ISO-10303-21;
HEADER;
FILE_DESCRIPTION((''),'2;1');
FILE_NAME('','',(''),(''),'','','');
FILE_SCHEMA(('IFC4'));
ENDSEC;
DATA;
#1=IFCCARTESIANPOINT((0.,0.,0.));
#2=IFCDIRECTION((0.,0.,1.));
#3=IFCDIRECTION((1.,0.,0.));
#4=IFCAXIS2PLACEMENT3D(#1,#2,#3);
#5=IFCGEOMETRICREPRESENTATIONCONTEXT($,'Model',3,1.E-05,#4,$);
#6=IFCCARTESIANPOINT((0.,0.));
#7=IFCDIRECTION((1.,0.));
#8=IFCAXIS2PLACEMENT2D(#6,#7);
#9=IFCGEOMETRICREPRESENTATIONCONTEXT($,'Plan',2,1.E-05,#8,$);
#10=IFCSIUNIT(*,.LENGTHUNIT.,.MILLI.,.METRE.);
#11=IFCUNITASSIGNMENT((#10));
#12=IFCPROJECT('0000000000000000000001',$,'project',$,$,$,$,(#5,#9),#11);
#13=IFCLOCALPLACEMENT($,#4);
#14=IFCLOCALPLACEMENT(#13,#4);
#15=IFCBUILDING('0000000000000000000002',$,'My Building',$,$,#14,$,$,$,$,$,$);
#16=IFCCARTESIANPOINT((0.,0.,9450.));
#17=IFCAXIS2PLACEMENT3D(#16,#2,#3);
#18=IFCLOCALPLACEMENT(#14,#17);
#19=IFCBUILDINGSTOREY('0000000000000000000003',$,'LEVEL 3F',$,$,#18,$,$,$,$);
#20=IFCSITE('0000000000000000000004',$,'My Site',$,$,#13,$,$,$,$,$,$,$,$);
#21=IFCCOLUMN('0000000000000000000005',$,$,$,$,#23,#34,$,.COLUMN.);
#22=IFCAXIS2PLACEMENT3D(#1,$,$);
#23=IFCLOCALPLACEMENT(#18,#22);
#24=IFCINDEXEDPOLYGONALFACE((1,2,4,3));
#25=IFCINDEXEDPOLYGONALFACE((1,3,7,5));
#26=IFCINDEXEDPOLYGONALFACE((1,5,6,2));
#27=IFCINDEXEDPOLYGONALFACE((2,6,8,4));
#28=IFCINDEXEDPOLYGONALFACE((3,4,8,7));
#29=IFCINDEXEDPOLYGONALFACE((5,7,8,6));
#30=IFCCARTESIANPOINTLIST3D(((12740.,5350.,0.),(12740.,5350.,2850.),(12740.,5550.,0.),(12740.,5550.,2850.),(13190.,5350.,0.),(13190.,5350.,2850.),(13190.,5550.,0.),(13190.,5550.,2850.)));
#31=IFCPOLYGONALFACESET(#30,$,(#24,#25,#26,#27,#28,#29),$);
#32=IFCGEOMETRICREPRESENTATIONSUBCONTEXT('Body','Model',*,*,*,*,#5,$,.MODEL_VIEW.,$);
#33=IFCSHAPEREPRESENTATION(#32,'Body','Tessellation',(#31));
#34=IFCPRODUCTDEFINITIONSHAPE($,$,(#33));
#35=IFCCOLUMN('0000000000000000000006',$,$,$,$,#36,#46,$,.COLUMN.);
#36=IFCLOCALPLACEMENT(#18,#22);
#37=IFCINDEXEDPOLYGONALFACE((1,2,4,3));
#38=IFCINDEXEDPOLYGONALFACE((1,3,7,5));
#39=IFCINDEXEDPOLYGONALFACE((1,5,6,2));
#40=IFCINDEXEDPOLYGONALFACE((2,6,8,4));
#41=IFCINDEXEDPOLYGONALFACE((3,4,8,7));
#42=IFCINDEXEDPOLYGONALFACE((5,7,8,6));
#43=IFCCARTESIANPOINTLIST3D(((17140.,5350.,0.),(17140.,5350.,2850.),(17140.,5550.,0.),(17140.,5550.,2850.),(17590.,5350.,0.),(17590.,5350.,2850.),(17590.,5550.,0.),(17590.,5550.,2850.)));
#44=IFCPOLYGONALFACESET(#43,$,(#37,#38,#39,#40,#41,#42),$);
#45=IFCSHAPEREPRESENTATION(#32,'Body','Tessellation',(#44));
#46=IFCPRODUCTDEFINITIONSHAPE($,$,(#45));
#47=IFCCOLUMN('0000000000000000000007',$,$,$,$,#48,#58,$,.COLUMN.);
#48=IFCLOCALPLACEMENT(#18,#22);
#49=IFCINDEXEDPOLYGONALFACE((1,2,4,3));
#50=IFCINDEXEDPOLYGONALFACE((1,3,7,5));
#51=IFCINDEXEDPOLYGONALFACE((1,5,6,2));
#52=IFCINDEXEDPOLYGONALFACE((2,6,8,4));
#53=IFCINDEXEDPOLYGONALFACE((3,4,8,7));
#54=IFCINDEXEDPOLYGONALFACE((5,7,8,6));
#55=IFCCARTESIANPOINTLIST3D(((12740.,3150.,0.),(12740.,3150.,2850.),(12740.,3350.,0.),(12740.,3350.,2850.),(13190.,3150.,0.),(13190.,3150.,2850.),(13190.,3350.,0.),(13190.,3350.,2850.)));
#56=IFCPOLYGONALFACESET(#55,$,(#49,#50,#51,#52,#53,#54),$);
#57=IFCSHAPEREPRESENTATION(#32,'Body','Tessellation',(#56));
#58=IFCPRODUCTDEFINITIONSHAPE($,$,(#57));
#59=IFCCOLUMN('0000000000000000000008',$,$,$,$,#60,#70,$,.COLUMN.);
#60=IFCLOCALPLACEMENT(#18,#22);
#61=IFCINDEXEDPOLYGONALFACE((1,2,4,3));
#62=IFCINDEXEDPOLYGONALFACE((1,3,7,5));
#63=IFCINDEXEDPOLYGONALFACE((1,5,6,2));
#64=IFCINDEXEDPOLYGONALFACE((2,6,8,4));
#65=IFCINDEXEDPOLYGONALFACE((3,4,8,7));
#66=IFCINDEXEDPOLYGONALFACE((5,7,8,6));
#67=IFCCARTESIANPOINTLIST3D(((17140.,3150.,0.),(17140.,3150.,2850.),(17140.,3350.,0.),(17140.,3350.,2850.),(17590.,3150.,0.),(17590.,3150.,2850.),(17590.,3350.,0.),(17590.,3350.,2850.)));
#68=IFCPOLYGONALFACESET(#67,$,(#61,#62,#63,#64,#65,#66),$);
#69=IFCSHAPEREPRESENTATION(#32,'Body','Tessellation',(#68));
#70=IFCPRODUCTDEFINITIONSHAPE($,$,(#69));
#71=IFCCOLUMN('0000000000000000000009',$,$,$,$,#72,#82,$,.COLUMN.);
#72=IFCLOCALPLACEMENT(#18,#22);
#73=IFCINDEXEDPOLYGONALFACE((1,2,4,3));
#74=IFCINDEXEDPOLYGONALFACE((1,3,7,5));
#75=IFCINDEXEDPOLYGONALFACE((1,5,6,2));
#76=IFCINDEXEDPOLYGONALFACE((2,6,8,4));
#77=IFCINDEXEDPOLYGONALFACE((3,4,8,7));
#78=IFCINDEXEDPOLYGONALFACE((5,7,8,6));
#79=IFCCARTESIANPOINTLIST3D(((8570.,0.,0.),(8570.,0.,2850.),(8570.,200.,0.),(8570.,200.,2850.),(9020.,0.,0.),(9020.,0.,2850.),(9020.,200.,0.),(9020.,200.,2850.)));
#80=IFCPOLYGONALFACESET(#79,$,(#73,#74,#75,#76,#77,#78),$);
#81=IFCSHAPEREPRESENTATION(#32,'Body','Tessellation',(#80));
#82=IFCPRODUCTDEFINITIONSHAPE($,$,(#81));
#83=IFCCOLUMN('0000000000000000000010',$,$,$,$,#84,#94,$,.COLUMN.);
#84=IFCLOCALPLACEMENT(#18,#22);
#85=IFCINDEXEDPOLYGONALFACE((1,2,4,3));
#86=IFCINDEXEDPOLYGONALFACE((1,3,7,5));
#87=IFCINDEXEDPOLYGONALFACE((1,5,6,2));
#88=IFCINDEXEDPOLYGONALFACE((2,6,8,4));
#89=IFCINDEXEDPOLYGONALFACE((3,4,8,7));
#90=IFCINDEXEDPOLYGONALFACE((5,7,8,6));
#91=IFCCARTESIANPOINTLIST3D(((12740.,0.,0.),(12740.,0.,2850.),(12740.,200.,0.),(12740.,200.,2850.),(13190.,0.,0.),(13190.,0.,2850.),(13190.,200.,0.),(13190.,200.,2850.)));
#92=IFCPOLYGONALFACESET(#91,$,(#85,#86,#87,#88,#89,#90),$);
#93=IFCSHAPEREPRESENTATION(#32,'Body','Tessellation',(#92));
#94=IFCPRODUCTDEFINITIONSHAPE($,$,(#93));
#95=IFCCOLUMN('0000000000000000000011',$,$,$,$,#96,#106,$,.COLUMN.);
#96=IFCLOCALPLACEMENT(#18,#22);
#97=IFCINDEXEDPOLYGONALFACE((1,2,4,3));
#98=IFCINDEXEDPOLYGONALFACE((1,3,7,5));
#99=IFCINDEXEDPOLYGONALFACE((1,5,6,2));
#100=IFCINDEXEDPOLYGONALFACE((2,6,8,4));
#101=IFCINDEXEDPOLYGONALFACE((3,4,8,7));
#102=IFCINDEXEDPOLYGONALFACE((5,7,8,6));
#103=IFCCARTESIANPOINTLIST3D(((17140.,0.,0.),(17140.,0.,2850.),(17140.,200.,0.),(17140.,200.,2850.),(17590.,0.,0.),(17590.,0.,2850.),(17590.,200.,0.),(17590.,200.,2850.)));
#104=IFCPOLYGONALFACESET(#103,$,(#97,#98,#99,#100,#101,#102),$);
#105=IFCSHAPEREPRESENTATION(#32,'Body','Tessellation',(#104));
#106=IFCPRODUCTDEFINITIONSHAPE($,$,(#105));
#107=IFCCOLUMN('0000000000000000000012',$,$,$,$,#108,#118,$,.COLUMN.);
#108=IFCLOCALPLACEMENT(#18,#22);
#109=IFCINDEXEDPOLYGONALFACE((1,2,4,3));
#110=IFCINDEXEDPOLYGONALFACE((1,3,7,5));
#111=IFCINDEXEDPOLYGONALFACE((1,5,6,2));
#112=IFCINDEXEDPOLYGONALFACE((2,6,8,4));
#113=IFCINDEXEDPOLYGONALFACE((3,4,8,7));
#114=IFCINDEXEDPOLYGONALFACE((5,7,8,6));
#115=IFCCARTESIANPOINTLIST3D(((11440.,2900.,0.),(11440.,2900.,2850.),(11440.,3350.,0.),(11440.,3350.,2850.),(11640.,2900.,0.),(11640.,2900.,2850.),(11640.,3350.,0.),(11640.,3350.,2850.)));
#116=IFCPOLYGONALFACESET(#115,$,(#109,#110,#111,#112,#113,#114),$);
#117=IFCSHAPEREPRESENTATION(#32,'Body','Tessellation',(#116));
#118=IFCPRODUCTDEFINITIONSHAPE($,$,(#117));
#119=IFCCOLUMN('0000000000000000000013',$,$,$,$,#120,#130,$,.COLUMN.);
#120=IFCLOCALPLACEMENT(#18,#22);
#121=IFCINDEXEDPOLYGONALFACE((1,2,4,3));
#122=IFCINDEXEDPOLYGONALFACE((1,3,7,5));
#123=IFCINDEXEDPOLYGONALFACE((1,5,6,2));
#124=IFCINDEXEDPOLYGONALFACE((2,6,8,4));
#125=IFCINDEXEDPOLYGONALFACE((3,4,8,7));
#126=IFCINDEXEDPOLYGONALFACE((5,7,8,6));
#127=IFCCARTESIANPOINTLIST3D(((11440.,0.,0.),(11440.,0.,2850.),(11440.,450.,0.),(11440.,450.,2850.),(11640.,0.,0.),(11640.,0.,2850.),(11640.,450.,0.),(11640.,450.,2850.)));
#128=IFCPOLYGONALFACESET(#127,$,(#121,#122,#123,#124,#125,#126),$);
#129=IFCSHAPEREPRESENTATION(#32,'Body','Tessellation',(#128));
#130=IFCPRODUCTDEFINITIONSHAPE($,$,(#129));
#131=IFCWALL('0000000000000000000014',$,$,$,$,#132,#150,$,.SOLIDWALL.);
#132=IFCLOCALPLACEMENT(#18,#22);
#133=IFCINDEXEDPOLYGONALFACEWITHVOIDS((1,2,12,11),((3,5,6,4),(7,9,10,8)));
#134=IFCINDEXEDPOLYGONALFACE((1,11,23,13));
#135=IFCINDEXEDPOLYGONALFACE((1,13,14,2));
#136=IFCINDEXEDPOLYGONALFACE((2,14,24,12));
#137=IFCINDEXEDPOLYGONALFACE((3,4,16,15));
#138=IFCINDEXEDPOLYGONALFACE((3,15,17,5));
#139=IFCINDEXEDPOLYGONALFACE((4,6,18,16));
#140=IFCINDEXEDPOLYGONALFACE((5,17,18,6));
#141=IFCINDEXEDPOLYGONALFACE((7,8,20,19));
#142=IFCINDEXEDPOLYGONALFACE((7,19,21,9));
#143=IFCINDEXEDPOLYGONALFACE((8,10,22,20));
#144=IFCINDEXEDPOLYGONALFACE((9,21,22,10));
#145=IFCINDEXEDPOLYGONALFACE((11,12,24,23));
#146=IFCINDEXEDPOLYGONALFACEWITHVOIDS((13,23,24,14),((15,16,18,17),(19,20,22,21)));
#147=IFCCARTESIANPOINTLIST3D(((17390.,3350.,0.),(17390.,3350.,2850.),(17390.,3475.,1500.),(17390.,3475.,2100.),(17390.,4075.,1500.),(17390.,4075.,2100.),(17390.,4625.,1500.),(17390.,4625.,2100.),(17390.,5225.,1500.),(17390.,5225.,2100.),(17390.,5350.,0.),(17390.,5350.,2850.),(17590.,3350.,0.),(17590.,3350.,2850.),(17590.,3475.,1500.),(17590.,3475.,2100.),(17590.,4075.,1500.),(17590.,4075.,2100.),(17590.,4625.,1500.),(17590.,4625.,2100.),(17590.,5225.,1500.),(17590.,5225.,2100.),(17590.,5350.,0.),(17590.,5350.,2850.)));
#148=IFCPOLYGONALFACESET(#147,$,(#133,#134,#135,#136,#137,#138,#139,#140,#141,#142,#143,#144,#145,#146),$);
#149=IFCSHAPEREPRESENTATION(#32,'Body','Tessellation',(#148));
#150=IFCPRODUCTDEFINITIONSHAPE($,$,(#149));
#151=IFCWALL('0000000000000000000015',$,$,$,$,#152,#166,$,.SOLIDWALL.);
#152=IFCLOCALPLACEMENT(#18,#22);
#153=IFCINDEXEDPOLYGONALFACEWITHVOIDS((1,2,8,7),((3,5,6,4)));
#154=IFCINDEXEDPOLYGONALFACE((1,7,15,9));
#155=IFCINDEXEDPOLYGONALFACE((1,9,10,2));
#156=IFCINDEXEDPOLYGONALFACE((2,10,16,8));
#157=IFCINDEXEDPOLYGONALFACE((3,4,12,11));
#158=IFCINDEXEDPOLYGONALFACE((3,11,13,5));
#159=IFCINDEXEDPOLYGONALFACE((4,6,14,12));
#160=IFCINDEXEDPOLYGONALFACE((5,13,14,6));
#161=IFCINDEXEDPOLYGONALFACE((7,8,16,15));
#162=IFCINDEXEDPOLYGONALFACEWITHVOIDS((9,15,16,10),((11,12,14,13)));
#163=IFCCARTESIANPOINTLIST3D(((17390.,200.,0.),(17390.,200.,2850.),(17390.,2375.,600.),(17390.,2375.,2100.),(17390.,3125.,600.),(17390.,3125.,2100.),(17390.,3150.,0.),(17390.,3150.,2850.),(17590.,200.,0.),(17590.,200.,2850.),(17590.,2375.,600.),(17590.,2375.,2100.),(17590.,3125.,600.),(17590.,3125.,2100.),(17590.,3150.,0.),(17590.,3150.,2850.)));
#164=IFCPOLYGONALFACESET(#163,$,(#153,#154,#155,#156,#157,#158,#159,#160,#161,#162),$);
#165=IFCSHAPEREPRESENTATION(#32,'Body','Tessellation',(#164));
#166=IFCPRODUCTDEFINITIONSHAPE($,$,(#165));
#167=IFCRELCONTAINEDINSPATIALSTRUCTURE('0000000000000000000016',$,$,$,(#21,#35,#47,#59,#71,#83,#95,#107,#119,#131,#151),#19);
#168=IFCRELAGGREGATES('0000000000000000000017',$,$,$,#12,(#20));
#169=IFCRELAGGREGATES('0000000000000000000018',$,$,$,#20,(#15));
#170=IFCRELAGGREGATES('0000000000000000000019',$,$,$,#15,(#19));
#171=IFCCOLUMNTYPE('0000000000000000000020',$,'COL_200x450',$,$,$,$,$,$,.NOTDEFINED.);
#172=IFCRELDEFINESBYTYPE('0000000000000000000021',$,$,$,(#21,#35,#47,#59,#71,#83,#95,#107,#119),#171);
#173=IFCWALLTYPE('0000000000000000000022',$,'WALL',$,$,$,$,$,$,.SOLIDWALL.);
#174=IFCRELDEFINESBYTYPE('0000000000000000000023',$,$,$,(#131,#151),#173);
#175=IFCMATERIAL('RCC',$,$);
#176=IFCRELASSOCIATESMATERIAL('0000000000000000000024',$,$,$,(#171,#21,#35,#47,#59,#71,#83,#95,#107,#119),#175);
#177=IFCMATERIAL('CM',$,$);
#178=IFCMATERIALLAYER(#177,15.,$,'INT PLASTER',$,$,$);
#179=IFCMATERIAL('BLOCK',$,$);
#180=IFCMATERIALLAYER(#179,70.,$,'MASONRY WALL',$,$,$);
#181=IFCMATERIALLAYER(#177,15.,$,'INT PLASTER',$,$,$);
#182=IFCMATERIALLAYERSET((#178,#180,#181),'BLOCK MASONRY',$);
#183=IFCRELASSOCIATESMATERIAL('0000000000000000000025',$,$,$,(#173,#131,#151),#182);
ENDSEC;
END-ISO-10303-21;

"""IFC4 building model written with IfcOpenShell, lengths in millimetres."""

from ifc_helpers import new_model, si_unit, frame, origin_with_axes, origin_2d_with_axis, place, context, subcontext, project, spatial, indexed_curve, rectangle, outline, extrude, material, layer, layer_set, layer_usage, material_profile, profile_set, profile_usage, type_object, element, save


model = new_model("IFC4")

# Units and contexts
model_context = context("Model", 3, precision=1e-05, world=origin_with_axes())
plan_context = context("Plan", 2, precision=1e-05, world=origin_2d_with_axis())
body_context = subcontext(model_context, "Body", "Model", "MODEL_VIEW")
ifc_project = project(units=[si_unit("LENGTHUNIT", "METRE", prefix="MILLI")], contexts=[model_context, plan_context])

# Site, building, storey
site_placement = place(None, origin_with_axes())
site = spatial("IfcSite", under=ifc_project, at=site_placement, Name="My Site")
building_placement = place(site_placement, origin_with_axes())
building = spatial("IfcBuilding", under=site, at=building_placement, Name="My Building")
storey_placement = place(building_placement, frame((0.0, 0.0, 9450.0), z_axis=(0.0, 0.0, 1.0), x_axis=(1.0, 0.0, 0.0)))
storey = spatial("IfcBuildingStorey", under=building, at=storey_placement, Name="LEVEL 3F")

# Columns
ifc_material_1 = material(Name="RCC")
ifc_material_profile = material_profile(ifc_material_1, rectangle(XDim=200.0, YDim=450.0))
ifc_profile_set = profile_set([ifc_material_profile], Name="COL_200x450")
ifc_profile_usage_1 = profile_usage(ifc_profile_set)
column_type = type_object("IfcColumnType", Name="COL_200x450", PredefinedType="NOTDEFINED", material=ifc_profile_set)
column_1_placement = place(storey_placement, frame((12965.0, 5450.0, 0.0), z_axis=(0.0, 0.0, 1.0), x_axis=(0.0, -1.0, 0.0)))
element("IfcColumn", 1, at=column_1_placement, inside=storey, type_object=column_type, material=ifc_profile_usage_1, PredefinedType="COLUMN", context=body_context, shape_type="SweptSolid", body=[
    extrude(rectangle(XDim=200.0, YDim=450.0), origin_with_axes(), (0.0, 0.0, 1.0), 2850.0),
])
ifc_profile_usage_2 = profile_usage(ifc_profile_set)
column_2_placement = place(storey_placement, frame((17365.0, 5450.0, 0.0), z_axis=(0.0, 0.0, 1.0), x_axis=(0.0, -1.0, 0.0)))
element("IfcColumn", 2, at=column_2_placement, inside=storey, type_object=column_type, material=ifc_profile_usage_2, PredefinedType="COLUMN", context=body_context, shape_type="SweptSolid", body=[
    extrude(rectangle(XDim=200.0, YDim=450.0), origin_with_axes(), (0.0, 0.0, 1.0), 2850.0),
])
ifc_profile_usage_3 = profile_usage(ifc_profile_set)
column_3_placement = place(storey_placement, frame((12965.0, 3250.0, 0.0), z_axis=(0.0, 0.0, 1.0), x_axis=(0.0, -1.0, 0.0)))
element("IfcColumn", 3, at=column_3_placement, inside=storey, type_object=column_type, material=ifc_profile_usage_3, PredefinedType="COLUMN", context=body_context, shape_type="SweptSolid", body=[
    extrude(rectangle(XDim=200.0, YDim=450.0), origin_with_axes(), (0.0, 0.0, 1.0), 2850.0),
])
ifc_profile_usage_4 = profile_usage(ifc_profile_set)
column_4_placement = place(storey_placement, frame((17365.0, 3250.0, 0.0), z_axis=(0.0, 0.0, 1.0), x_axis=(0.0, -1.0, 0.0)))
element("IfcColumn", 4, at=column_4_placement, inside=storey, type_object=column_type, material=ifc_profile_usage_4, PredefinedType="COLUMN", context=body_context, shape_type="SweptSolid", body=[
    extrude(rectangle(XDim=200.0, YDim=450.0), origin_with_axes(), (0.0, 0.0, 1.0), 2850.0),
])
ifc_profile_usage_5 = profile_usage(ifc_profile_set)
column_5_placement = place(storey_placement, frame((8795.0, 100.0, 0.0), z_axis=(0.0, 0.0, 1.0), x_axis=(0.0, -1.0, 0.0)))
element("IfcColumn", 5, at=column_5_placement, inside=storey, type_object=column_type, material=ifc_profile_usage_5, PredefinedType="COLUMN", context=body_context, shape_type="SweptSolid", body=[
    extrude(rectangle(XDim=200.0, YDim=450.0), origin_with_axes(), (0.0, 0.0, 1.0), 2850.0),
])
ifc_profile_usage_6 = profile_usage(ifc_profile_set)
column_6_placement = place(storey_placement, frame((12965.0, 100.0, 0.0), z_axis=(0.0, 0.0, 1.0), x_axis=(0.0, -1.0, 0.0)))
element("IfcColumn", 6, at=column_6_placement, inside=storey, type_object=column_type, material=ifc_profile_usage_6, PredefinedType="COLUMN", context=body_context, shape_type="SweptSolid", body=[
    extrude(rectangle(XDim=200.0, YDim=450.0), origin_with_axes(), (0.0, 0.0, 1.0), 2850.0),
])
ifc_profile_usage_7 = profile_usage(ifc_profile_set)
column_7_placement = place(storey_placement, frame((17365.0, 100.0, 0.0), z_axis=(0.0, 0.0, 1.0), x_axis=(0.0, -1.0, 0.0)))
element("IfcColumn", 7, at=column_7_placement, inside=storey, type_object=column_type, material=ifc_profile_usage_7, PredefinedType="COLUMN", context=body_context, shape_type="SweptSolid", body=[
    extrude(rectangle(XDim=200.0, YDim=450.0), origin_with_axes(), (0.0, 0.0, 1.0), 2850.0),
])
ifc_profile_usage_8 = profile_usage(ifc_profile_set)
column_8_placement = place(storey_placement, frame((11540.0, 3125.0, 0.0), z_axis=(0.0, 0.0, 1.0), x_axis=(1.0, 0.0, 0.0)))
element("IfcColumn", 8, at=column_8_placement, inside=storey, type_object=column_type, material=ifc_profile_usage_8, PredefinedType="COLUMN", context=body_context, shape_type="SweptSolid", body=[
    extrude(rectangle(XDim=200.0, YDim=450.0), origin_with_axes(), (0.0, 0.0, 1.0), 2850.0),
])
ifc_profile_usage_9 = profile_usage(ifc_profile_set)
column_9_placement = place(storey_placement, frame((11540.0, 225.0, 0.0), z_axis=(0.0, 0.0, 1.0), x_axis=(1.0, 0.0, 0.0)))
element("IfcColumn", 9, at=column_9_placement, inside=storey, type_object=column_type, material=ifc_profile_usage_9, PredefinedType="COLUMN", context=body_context, shape_type="SweptSolid", body=[
    extrude(rectangle(XDim=200.0, YDim=450.0), origin_with_axes(), (0.0, 0.0, 1.0), 2850.0),
])

# Wall, openings
ifc_material_2 = material(Name="CM")
ifc_layer_1 = layer(ifc_material_2, 15.0, Name="INT PLASTER")
ifc_material_3 = material(Name="BLOCK")
ifc_layer_2 = layer(ifc_material_3, 70.0, Name="MASONRY WALL")
ifc_layer_3 = layer(ifc_material_2, 15.0, Name="INT PLASTER")
ifc_layer_set = layer_set([ifc_layer_1, ifc_layer_2, ifc_layer_3], Name="BLOCK MASONRY")
ifc_layer_usage_1 = layer_usage(ifc_layer_set, "AXIS2", "POSITIVE", 0.0)
wall_type = type_object("IfcWallType", Name="WALL", PredefinedType="SOLIDWALL", material=ifc_layer_set)
wall_1_placement = place(storey_placement, frame((17590.0, 3350.0, 0.0), z_axis=(0.0, 0.0, 1.0), x_axis=(0.0, 1.0, 0.0)))
wall_1 = element("IfcWall", 10, at=wall_1_placement, inside=storey, type_object=wall_type, material=ifc_layer_usage_1, PredefinedType="SOLIDWALL", context=body_context, shape_type="SweptSolid", body=[
    extrude(outline(indexed_curve([(0.0, 0.0), (0.0, 200.0), (2000.0, 200.0), (2000.0, 0.0), (0.0, 0.0)], self_intersect=False)), origin_with_axes(), (0.0, 0.0, 1.0), 2850.0),
])
opening_1_placement = place(wall_1_placement, frame((1875.0, 200.0, 1500.0), z_axis=(0.0, 0.0, 1.0), x_axis=(-1.0, 0.0, 0.0)))
element("IfcOpeningElement", 11, at=opening_1_placement, cuts=wall_1, PredefinedType="OPENING", context=body_context, shape_type="SweptSolid", body=[
    extrude(outline(indexed_curve([(0.0, 0.0), (0.0, 400.0), (600.0, 400.0), (600.0, 0.0), (0.0, 0.0)], self_intersect=False)), frame((0.0, -100.0, 0.0), z_axis=(0.0, 0.0, 1.0), x_axis=(1.0, 0.0, 0.0)), (0.0, 0.0, 1.0), 600.0),
])
opening_2_placement = place(wall_1_placement, frame((725.0, 200.0, 1500.0), z_axis=(0.0, 0.0, 1.0), x_axis=(-1.0, 0.0, 0.0)))
element("IfcOpeningElement", 12, at=opening_2_placement, cuts=wall_1, PredefinedType="OPENING", context=body_context, shape_type="SweptSolid", body=[
    extrude(outline(indexed_curve([(0.0, 0.0), (0.0, 400.0), (600.0, 400.0), (600.0, 0.0), (0.0, 0.0)], self_intersect=False)), frame((0.0, -100.0, 0.0), z_axis=(0.0, 0.0, 1.0), x_axis=(1.0, 0.0, 0.0)), (0.0, 0.0, 1.0), 600.0),
])

# Wall, opening
ifc_layer_usage_2 = layer_usage(ifc_layer_set, "AXIS2", "POSITIVE", 0.0)
wall_2_placement = place(storey_placement, frame((17590.0, 200.0, 0.0), z_axis=(0.0, 0.0, 1.0), x_axis=(0.0, 1.0, 0.0)))
wall_2 = element("IfcWall", 13, at=wall_2_placement, inside=storey, type_object=wall_type, material=ifc_layer_usage_2, PredefinedType="SOLIDWALL", context=body_context, shape_type="SweptSolid", body=[
    extrude(outline(indexed_curve([(0.0, 0.0), (0.0, 200.0), (2950.0, 200.0), (2950.0, 0.0), (0.0, 0.0)], self_intersect=False)), origin_with_axes(), (0.0, 0.0, 1.0), 2850.0),
])
opening_3_placement = place(wall_2_placement, frame((2925.0, 200.0, 600.0), z_axis=(0.0, 0.0, 1.0), x_axis=(-1.0, 0.0, 0.0)))
element("IfcOpeningElement", 14, at=opening_3_placement, cuts=wall_2, PredefinedType="OPENING", context=body_context, shape_type="SweptSolid", body=[
    extrude(outline(indexed_curve([(0.0, 0.0), (0.0, 400.0), (750.0, 400.0), (750.0, 0.0), (0.0, 0.0)], self_intersect=False)), frame((0.0, -100.0, 0.0), z_axis=(0.0, 0.0, 1.0), x_axis=(1.0, 0.0, 0.0)), (0.0, 0.0, 1.0), 1500.0),
])

save(model, "model.ifc")
